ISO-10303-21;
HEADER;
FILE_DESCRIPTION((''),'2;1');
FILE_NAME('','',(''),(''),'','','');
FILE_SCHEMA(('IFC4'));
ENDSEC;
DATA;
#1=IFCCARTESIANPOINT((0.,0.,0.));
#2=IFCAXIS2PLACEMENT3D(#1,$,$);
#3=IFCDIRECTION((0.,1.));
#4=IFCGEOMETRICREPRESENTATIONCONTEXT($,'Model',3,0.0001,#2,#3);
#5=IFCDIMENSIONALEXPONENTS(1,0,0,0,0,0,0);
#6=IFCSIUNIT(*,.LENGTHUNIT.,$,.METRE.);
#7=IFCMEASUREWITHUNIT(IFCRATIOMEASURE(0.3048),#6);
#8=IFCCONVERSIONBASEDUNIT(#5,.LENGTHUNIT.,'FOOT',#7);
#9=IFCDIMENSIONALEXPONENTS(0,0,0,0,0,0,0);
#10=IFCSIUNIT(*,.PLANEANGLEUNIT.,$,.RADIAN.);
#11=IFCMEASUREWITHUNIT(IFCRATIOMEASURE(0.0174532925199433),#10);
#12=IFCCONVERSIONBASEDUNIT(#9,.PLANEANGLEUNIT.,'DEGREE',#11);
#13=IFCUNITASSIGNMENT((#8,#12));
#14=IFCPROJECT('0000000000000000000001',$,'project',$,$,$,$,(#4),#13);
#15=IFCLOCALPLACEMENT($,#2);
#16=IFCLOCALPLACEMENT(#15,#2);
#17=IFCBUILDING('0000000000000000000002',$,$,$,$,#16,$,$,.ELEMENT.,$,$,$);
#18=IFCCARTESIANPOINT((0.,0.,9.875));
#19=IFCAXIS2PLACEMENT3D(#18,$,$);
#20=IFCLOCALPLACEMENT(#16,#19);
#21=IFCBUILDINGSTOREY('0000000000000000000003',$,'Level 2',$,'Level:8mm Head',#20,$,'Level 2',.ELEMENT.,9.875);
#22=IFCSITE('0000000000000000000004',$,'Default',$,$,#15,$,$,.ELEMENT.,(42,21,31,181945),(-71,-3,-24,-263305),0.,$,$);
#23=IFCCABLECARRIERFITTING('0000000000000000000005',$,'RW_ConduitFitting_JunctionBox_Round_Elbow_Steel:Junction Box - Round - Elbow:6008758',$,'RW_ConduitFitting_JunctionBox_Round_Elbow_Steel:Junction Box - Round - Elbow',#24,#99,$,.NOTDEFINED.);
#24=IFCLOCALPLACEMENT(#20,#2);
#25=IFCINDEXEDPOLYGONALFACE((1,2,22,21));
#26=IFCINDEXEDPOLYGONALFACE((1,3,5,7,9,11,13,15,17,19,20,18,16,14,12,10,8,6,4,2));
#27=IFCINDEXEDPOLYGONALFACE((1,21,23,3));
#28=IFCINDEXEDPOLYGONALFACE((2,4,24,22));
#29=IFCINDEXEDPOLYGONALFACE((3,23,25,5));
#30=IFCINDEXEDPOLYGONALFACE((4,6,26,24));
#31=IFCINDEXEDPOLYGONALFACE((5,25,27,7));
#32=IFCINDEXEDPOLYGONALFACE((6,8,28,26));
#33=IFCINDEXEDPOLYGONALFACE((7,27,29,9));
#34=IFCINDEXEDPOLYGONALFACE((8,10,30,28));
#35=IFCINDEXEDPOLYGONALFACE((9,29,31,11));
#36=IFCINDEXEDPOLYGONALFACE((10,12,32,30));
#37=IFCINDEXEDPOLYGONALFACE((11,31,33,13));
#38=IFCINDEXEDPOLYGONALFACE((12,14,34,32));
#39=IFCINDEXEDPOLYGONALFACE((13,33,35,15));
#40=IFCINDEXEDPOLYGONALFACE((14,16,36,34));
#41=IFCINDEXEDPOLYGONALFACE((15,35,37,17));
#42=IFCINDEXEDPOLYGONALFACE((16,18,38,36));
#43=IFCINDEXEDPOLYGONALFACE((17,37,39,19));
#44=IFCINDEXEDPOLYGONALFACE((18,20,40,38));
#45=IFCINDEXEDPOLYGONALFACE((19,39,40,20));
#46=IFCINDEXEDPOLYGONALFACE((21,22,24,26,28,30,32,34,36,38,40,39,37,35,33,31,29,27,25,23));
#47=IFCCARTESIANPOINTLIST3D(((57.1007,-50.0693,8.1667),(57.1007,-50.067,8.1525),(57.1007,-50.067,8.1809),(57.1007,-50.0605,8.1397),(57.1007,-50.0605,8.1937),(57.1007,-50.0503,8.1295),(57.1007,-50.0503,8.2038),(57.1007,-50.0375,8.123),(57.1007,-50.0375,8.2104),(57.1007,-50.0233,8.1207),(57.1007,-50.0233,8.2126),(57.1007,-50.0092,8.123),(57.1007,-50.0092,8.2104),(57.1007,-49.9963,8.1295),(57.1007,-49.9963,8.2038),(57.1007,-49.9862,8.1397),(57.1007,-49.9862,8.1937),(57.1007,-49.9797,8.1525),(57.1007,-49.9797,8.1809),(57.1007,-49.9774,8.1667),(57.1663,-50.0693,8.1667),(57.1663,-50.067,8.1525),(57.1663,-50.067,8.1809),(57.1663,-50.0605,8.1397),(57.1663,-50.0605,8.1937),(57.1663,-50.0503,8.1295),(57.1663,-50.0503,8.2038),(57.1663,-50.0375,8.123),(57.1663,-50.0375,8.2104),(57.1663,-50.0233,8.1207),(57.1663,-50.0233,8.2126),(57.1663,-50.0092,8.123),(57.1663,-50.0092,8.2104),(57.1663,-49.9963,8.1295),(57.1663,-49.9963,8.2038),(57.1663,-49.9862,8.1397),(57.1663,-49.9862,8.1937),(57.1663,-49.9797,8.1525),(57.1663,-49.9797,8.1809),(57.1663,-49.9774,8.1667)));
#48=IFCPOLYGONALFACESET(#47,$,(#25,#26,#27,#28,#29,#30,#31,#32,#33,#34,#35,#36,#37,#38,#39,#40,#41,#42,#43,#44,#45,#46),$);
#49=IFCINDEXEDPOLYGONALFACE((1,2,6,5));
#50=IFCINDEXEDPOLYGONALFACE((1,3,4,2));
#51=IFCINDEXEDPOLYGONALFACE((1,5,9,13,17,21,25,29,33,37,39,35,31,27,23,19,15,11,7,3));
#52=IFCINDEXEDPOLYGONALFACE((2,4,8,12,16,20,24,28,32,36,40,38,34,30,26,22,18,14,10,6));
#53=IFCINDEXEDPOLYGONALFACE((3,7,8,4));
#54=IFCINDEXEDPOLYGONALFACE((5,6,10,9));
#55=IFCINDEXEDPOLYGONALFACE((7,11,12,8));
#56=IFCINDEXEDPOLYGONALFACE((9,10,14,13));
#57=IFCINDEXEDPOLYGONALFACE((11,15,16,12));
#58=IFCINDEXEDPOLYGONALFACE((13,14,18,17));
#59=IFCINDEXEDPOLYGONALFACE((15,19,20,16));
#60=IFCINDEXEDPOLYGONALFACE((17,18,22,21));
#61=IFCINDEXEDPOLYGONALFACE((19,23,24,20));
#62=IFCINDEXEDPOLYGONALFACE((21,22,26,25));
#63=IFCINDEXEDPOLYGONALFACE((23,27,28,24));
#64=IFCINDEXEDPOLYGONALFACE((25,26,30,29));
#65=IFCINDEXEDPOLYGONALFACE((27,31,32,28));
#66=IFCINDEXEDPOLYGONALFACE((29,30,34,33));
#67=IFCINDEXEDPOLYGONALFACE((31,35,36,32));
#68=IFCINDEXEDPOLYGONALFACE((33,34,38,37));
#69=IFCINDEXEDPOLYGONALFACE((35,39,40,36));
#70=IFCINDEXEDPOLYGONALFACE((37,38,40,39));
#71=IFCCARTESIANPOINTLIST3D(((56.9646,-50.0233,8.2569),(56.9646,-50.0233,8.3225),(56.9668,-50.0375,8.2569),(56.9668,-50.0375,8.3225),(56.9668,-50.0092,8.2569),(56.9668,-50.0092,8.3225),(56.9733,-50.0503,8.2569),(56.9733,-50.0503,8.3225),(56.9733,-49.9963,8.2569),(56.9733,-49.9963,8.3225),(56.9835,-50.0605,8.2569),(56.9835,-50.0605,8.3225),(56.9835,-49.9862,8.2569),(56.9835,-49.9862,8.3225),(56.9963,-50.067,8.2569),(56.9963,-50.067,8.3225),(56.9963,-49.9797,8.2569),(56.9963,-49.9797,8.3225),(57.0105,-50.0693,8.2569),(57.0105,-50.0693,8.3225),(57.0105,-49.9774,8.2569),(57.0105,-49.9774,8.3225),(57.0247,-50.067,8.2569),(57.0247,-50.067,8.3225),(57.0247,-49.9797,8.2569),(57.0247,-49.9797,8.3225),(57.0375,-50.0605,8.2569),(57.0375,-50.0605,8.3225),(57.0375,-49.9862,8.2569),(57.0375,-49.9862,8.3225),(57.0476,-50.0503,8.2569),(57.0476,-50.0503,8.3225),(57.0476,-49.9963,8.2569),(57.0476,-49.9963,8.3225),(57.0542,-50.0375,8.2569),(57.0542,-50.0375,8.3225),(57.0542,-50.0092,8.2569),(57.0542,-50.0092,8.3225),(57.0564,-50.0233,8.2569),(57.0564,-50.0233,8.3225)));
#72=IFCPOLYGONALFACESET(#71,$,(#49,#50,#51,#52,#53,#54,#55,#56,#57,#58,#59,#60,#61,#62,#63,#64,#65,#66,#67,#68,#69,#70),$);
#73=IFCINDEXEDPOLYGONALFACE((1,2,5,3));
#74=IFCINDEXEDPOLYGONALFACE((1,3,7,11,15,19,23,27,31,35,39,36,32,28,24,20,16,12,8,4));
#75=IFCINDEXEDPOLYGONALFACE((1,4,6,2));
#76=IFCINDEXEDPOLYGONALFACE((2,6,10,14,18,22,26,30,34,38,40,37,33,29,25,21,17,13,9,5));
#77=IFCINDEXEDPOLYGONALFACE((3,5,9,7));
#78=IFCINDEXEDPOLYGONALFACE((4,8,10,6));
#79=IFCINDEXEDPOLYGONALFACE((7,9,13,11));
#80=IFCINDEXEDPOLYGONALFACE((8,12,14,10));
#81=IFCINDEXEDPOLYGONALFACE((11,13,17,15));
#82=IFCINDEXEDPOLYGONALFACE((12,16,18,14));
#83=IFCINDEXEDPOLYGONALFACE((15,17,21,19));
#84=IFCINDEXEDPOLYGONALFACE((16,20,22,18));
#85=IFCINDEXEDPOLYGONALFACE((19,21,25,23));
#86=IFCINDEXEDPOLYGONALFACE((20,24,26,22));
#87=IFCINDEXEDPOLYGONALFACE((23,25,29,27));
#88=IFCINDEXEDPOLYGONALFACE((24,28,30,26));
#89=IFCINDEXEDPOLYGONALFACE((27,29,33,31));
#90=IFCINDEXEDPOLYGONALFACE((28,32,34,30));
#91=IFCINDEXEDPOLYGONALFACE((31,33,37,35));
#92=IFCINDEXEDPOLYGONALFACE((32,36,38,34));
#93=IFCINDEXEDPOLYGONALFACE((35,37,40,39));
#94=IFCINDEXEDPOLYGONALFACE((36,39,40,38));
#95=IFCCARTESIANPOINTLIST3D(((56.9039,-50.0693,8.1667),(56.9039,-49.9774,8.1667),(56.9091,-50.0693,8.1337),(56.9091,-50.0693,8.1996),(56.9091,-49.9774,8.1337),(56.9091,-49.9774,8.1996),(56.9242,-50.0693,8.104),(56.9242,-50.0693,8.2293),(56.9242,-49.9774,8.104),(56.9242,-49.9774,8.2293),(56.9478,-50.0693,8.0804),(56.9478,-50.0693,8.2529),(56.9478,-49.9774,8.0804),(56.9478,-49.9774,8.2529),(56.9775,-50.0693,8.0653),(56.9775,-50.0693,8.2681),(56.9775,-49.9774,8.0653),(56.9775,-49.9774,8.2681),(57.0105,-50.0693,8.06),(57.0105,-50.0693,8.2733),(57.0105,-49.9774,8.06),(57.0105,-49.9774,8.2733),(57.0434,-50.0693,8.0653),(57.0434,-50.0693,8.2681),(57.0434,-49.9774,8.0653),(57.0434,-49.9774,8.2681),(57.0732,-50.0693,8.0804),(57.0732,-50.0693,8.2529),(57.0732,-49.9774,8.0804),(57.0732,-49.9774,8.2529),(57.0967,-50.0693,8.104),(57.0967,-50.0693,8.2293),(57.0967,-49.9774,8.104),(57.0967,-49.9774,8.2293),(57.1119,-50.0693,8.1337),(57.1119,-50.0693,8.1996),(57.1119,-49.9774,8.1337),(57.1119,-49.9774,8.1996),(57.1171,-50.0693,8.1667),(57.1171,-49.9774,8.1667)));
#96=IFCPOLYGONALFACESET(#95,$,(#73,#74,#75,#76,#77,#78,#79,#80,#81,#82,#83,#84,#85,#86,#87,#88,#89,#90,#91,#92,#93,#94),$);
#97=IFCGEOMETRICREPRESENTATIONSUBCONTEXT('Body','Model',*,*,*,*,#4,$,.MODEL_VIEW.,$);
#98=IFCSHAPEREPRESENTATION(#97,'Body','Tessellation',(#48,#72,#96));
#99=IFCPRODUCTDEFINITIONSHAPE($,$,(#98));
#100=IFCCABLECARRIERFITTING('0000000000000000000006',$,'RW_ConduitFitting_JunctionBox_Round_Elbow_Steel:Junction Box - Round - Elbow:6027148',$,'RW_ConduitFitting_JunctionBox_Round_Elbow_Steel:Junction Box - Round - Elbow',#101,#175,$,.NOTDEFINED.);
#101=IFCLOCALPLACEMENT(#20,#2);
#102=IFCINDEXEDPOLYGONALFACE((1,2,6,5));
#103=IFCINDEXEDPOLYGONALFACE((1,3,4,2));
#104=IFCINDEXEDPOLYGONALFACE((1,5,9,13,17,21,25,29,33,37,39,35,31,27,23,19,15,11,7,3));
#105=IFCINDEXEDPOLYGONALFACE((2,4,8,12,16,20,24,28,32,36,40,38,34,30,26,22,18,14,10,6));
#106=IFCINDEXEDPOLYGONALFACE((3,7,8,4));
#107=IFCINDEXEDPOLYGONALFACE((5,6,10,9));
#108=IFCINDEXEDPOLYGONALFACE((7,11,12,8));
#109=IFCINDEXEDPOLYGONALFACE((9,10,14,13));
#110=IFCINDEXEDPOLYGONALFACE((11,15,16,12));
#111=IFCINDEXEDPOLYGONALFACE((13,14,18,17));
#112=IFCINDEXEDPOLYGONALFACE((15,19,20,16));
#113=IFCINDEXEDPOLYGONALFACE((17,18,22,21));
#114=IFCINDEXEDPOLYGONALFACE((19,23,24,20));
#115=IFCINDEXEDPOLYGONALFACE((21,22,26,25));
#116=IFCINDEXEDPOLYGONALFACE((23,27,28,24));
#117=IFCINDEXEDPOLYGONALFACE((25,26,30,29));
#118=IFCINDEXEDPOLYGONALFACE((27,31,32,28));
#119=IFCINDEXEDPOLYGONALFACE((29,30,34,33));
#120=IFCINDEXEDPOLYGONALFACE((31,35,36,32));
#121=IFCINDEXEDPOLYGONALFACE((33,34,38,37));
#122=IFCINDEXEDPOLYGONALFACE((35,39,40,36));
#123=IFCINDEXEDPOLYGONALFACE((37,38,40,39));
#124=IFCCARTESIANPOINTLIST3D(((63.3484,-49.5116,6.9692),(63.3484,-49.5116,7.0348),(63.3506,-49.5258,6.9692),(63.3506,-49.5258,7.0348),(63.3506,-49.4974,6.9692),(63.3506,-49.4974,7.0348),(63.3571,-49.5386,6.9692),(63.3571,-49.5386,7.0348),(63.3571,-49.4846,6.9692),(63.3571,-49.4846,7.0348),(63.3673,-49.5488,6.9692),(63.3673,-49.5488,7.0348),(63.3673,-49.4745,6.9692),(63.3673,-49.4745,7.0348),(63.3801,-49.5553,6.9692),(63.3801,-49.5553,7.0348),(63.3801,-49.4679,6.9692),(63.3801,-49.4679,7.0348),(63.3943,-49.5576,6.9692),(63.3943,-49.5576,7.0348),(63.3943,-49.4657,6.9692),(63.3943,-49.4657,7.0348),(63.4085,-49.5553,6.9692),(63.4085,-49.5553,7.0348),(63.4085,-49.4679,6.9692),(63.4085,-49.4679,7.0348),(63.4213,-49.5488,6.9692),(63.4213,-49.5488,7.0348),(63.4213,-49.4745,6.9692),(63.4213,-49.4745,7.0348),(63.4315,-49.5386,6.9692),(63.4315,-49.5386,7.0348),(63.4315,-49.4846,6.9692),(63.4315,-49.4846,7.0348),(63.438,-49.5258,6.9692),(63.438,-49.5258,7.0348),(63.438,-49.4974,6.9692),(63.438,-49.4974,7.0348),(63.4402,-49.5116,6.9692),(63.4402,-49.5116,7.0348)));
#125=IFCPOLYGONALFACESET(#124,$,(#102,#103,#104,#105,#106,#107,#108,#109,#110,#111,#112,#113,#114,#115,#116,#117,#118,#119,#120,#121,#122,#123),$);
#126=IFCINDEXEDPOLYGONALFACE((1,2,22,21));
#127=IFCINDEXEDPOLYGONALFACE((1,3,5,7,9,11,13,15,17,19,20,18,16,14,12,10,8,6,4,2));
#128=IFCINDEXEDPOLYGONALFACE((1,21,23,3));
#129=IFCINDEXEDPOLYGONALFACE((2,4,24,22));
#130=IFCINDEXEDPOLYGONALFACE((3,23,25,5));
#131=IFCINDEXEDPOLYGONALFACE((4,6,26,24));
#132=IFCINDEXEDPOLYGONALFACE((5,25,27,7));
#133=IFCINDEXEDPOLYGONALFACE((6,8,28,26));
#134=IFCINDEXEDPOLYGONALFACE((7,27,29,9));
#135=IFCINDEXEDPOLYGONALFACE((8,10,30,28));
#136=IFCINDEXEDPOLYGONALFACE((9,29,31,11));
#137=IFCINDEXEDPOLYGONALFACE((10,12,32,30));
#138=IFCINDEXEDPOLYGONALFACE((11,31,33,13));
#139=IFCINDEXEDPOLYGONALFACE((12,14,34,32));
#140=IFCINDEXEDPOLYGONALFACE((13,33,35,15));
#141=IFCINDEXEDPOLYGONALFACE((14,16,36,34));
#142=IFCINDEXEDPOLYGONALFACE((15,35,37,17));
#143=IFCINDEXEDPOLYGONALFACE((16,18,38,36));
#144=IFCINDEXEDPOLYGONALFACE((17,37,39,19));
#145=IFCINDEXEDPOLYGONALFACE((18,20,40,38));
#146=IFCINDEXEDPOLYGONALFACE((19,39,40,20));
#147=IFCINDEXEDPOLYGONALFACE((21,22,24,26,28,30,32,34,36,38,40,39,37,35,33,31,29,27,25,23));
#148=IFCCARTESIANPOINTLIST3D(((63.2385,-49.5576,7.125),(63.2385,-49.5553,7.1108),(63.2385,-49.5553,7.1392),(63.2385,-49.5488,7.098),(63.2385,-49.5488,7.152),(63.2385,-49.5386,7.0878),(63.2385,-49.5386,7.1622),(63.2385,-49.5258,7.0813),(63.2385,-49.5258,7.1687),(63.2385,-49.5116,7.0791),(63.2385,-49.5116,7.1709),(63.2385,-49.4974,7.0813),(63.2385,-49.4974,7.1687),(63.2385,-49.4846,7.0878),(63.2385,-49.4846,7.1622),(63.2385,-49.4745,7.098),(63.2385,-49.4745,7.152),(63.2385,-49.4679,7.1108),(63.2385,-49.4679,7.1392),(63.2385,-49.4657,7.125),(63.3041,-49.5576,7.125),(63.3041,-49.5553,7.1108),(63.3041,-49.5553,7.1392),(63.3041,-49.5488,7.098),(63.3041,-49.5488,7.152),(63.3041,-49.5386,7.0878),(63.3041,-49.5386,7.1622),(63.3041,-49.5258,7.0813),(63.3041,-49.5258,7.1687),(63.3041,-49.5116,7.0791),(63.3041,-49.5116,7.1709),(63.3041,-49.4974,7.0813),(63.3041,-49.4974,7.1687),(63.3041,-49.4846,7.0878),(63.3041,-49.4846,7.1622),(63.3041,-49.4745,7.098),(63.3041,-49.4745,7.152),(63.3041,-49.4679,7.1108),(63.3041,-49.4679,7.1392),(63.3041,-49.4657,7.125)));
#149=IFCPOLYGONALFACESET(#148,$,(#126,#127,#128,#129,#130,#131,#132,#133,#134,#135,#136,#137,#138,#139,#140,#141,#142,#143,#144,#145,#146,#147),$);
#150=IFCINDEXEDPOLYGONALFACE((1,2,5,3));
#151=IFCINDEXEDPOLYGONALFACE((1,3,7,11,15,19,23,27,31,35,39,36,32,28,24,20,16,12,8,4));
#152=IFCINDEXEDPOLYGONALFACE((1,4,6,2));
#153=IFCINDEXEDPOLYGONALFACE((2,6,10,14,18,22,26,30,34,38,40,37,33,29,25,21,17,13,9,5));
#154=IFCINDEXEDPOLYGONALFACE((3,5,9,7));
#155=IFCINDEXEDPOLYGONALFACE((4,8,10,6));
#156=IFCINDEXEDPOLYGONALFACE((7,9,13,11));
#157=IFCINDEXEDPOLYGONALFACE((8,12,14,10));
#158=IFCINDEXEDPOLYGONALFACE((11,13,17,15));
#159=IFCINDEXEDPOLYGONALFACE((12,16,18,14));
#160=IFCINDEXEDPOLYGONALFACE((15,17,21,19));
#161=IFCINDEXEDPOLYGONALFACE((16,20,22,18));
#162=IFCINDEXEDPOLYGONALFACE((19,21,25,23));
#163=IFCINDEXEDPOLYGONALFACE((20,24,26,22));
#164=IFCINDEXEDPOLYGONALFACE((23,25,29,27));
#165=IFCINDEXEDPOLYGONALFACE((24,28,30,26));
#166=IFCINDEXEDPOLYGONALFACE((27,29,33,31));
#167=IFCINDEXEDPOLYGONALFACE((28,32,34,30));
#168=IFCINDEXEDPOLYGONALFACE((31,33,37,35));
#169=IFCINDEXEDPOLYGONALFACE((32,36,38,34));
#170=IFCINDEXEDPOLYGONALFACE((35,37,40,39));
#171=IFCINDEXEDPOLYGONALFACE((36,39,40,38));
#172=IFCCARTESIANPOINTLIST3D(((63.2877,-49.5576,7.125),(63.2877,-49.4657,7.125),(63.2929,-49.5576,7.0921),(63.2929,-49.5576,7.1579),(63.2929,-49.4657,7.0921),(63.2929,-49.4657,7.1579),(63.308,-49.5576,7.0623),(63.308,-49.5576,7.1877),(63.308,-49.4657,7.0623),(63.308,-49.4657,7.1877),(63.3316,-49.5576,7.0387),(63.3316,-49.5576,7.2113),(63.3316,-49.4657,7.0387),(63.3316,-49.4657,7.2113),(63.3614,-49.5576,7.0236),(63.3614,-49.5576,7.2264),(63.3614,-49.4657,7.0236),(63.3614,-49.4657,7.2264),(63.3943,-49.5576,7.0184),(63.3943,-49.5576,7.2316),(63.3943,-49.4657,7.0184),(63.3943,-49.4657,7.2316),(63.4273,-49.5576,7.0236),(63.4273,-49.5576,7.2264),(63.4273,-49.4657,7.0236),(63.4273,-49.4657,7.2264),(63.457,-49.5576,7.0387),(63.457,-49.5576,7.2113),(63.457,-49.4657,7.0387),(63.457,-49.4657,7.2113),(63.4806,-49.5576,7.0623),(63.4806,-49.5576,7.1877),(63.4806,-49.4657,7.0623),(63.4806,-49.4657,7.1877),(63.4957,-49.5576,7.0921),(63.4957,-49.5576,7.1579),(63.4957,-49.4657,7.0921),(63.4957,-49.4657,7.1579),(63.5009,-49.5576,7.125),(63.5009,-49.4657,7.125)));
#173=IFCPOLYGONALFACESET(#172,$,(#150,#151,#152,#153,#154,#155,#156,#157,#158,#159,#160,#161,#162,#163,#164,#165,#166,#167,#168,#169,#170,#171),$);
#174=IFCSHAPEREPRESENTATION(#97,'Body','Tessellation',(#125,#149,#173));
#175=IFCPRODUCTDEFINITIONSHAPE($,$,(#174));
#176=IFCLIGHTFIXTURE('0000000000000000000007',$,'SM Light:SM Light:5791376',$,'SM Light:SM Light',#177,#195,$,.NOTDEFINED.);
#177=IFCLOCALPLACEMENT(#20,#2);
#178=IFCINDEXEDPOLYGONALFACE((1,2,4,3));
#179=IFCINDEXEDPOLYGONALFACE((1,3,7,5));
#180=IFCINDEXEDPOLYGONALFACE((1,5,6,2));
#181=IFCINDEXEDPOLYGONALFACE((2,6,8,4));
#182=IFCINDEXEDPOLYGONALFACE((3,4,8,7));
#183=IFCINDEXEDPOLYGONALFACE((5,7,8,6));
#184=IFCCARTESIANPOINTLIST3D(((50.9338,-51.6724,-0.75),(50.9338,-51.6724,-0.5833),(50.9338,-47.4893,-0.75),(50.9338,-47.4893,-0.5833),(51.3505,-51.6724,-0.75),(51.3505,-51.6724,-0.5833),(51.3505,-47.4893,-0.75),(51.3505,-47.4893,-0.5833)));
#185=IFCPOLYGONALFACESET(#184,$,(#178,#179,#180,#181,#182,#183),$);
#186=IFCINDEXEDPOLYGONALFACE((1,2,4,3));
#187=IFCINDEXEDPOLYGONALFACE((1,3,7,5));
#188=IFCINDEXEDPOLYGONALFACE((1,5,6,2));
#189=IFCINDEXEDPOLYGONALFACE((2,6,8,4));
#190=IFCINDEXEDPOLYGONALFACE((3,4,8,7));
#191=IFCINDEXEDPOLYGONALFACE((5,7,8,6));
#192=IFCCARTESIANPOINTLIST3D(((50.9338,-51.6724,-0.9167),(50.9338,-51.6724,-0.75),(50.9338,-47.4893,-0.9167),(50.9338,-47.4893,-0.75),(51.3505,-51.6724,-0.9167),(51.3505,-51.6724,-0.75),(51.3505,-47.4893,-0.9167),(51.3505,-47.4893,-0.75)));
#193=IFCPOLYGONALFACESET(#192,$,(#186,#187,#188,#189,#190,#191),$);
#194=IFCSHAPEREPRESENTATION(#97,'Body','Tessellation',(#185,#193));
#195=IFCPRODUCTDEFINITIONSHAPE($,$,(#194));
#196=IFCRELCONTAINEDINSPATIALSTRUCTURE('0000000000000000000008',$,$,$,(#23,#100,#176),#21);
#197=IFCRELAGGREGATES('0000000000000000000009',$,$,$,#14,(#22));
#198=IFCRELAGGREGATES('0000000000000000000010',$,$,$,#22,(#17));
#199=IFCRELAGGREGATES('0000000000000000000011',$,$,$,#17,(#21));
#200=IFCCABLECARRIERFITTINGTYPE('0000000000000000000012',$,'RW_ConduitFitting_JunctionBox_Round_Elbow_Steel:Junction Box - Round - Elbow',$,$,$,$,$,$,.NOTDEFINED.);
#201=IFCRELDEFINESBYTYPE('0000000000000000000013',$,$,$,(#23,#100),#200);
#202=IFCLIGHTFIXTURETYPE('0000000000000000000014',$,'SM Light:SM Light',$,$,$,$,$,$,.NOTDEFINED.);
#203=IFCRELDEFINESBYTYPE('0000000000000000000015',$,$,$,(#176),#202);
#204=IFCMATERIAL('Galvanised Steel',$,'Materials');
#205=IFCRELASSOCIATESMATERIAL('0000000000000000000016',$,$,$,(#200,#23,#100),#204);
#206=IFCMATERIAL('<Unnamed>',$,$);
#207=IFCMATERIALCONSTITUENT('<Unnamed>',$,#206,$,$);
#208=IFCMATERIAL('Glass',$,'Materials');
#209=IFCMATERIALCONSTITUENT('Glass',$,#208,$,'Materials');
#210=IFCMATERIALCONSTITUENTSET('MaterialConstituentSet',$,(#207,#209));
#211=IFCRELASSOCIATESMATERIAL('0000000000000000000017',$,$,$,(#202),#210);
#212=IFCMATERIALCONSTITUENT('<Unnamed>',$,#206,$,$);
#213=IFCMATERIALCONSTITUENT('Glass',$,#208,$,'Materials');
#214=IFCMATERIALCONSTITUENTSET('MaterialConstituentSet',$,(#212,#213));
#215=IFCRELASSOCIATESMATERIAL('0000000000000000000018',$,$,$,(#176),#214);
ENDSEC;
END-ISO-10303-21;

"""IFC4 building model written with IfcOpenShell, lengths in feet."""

from ifc_helpers import new_model, entity, si_unit, converted_unit, direction, frame, origin, place, context, subcontext, project, spatial, indexed_curve, outline, extrude, source, transform, mapped, material, constituent, constituent_set, type_object, type_shapes, element, save


model = new_model("IFC4")

# Units and contexts
model_context = context("Model", 3, precision=0.0001, world=origin(), true_north=direction((0.0, 1.0)))
body_context = subcontext(model_context, "Body", "Model", "MODEL_VIEW")
ifc_project = project(units=[converted_unit("LENGTHUNIT", "FOOT", entity("IfcRatioMeasure", 0.3048), si_unit("LENGTHUNIT", "METRE"), dimensions=[1, 0, 0, 0, 0, 0, 0]), converted_unit("PLANEANGLEUNIT", "DEGREE", entity("IfcRatioMeasure", 0.0174532925199433), si_unit("PLANEANGLEUNIT", "RADIAN"), dimensions=[0, 0, 0, 0, 0, 0, 0])], contexts=[model_context])

# Site, building, storey
site_placement = place(None, origin())
site = spatial("IfcSite", under=ifc_project, at=site_placement, Name="Default", CompositionType="ELEMENT", RefLatitude=(42, 21, 31, 181945), RefLongitude=(-71, -3, -24, -263305), RefElevation=0.0)
building_placement = place(site_placement, origin())
building = spatial("IfcBuilding", under=site, at=building_placement, CompositionType="ELEMENT")
storey_placement = place(building_placement, frame((0.0, 0.0, 9.875)))
storey = spatial("IfcBuildingStorey", under=building, at=storey_placement, Name="Level 2", ObjectType="Level:8mm Head", LongName="Level 2", CompositionType="ELEMENT", Elevation=9.875)

# Cable carrier fittings
ifc_material_1 = material(Name="Galvanised Steel", Category="Materials")
cable_carrier_fitting_type_1 = type_object("IfcCableCarrierFittingType", Name="RW_ConduitFitting_JunctionBox_Round_Elbow_Steel:Junction Box - Round - Elbow", PredefinedType="NOTDEFINED", material=ifc_material_1)
shared_shape_1 = source(origin(), body_context, "Body", "SweptSolid", [
    extrude(outline(indexed_curve([(0.0459, 0.0), (0.0437, 0.0142), (0.0372, 0.027), (0.027, 0.0372), (0.0142, 0.0437), (0.0, 0.0459), (-0.0142, 0.0437), (-0.027, 0.0372), (-0.0372, 0.027), (-0.0437, 0.0142), (-0.0459, 0.0), (-0.0437, -0.0142), (-0.0372, -0.027), (-0.027, -0.0372), (-0.0142, -0.0437), (0.0, -0.0459), (0.0142, -0.0437), (0.027, -0.0372), (0.0372, -0.027), (0.0437, -0.0142), (0.0459, 0.0)], self_intersect=False)), frame((0.0, 0.0902, 0.0), z_axis=(0.0, 1.0, 0.0), x_axis=(-1.0, 0.0, 0.0)), (0.0, 0.0, 1.0), 0.0656),
    extrude(outline(indexed_curve([(0.0459, 0.0), (0.0437, 0.0142), (0.0372, 0.027), (0.027, 0.0372), (0.0142, 0.0437), (0.0, 0.0459), (-0.0142, 0.0437), (-0.027, 0.0372), (-0.0372, 0.027), (-0.0437, 0.0142), (-0.0459, 0.0), (-0.0437, -0.0142), (-0.0372, -0.027), (-0.027, -0.0372), (-0.0142, -0.0437), (0.0, -0.0459), (0.0142, -0.0437), (0.027, -0.0372), (0.0372, -0.027), (0.0437, -0.0142), (0.0459, 0.0)], self_intersect=False)), frame((-0.1558, 0.0, 0.0), z_axis=(1.0, 0.0, 0.0), x_axis=(0.0, 1.0, 0.0)), (0.0, 0.0, 1.0), 0.0656),
    extrude(outline(indexed_curve([(0.1066, 0.0), (0.1014, 0.0329), (0.0863, 0.0627), (0.0627, 0.0863), (0.0329, 0.1014), (0.0, 0.1066), (-0.0329, 0.1014), (-0.0627, 0.0863), (-0.0863, 0.0627), (-0.1014, 0.0329), (-0.1066, 0.0), (-0.1014, -0.0329), (-0.0863, -0.0627), (-0.0627, -0.0863), (-0.0329, -0.1014), (0.0, -0.1066), (0.0329, -0.1014), (0.0627, -0.0863), (0.0863, -0.0627), (0.1014, -0.0329), (0.1066, 0.0)], self_intersect=False)), frame((0.0, 0.0, -0.0459)), (0.0, 0.0, 1.0), 0.0919),
])
type_shapes(cable_carrier_fitting_type_1, [shared_shape_1])
for number, where, z_axis, x_axis, name in (
    (1, (57.0105, -50.0233, 8.1667), (0.0, -1.0, 0.0), (0.0, 0.0, -1.0), "RW_ConduitFitting_JunctionBox_Round_Elbow_Steel:Junction Box - Round - Elbow:6008758"),
    (2, (63.3943, -49.5116, 7.125), (0.0, 1.0, 0.0), (1.0, 0.0, 0.0), "RW_ConduitFitting_JunctionBox_Round_Elbow_Steel:Junction Box - Round - Elbow:6027148"),
):
    element("IfcCableCarrierFitting", number, at=place(storey_placement, frame(where, z_axis=z_axis, x_axis=x_axis)), inside=storey, type_object=cable_carrier_fitting_type_1, material=ifc_material_1, Name=name, ObjectType="RW_ConduitFitting_JunctionBox_Round_Elbow_Steel:Junction Box - Round - Elbow", PredefinedType="NOTDEFINED", context=body_context, shape_type="MappedRepresentation", body=[
        mapped(shared_shape_1, transform((0.0, 0.0, 0.0), scale=1.0)),
    ])

# Light fixture
ifc_material_2 = material(Name="<Unnamed>")
ifc_constituent_1 = constituent(ifc_material_2, Name="<Unnamed>")
ifc_material_3 = material(Name="Glass", Category="Materials")
ifc_constituent_2 = constituent(ifc_material_3, Name="Glass", Category="Materials")
ifc_constituent_set_1 = constituent_set(constituents=[ifc_constituent_1, ifc_constituent_2], Name="MaterialConstituentSet")
ifc_constituent_3 = constituent(ifc_material_2, Name="<Unnamed>")
ifc_constituent_4 = constituent(ifc_material_3, Name="Glass", Category="Materials")
ifc_constituent_set_2 = constituent_set(constituents=[ifc_constituent_3, ifc_constituent_4], Name="MaterialConstituentSet")
light_fixture_type = type_object("IfcLightFixtureType", Name="SM Light:SM Light", PredefinedType="NOTDEFINED", material=ifc_constituent_set_2)
shared_shape_2 = source(origin(), body_context, "Body", "SweptSolid", [
    extrude(outline(indexed_curve([(-0.2083, -2.0915), (0.2083, -2.0915), (0.2083, 2.0915), (-0.2083, 2.0915), (-0.2083, -2.0915)], self_intersect=False)), frame((-0.0016, -0.2083, 0.1667), z_axis=(0.0, 0.0, 1.0), x_axis=(0.0, 1.0, 0.0)), (0.0, 0.0, 1.0), 0.1667),
    extrude(outline(indexed_curve([(-0.2083, -2.0915), (0.2083, -2.0915), (0.2083, 2.0915), (-0.2083, 2.0915), (-0.2083, -2.0915)], self_intersect=False)), frame((-0.0016, -0.2083, 0.0), z_axis=(0.0, 0.0, 1.0), x_axis=(0.0, 1.0, 0.0)), (0.0, 0.0, 1.0), 0.1667),
])
type_shapes(light_fixture_type, [shared_shape_2])
light_fixture_1_placement = place(storey_placement, frame((50.9338, -49.5792, -0.9167), z_axis=(0.0, 0.0, 1.0), x_axis=(0.0, 1.0, 0.0)))
element("IfcLightFixture", 3, at=light_fixture_1_placement, inside=storey, type_object=light_fixture_type, material=ifc_constituent_set_1, Name="SM Light:SM Light:5791376", ObjectType="SM Light:SM Light", PredefinedType="NOTDEFINED", context=body_context, shape_type="MappedRepresentation", body=[
    mapped(shared_shape_2, transform((0.0, 0.0, 0.0), scale=1.0)),
])

save(model, "model.ifc")
